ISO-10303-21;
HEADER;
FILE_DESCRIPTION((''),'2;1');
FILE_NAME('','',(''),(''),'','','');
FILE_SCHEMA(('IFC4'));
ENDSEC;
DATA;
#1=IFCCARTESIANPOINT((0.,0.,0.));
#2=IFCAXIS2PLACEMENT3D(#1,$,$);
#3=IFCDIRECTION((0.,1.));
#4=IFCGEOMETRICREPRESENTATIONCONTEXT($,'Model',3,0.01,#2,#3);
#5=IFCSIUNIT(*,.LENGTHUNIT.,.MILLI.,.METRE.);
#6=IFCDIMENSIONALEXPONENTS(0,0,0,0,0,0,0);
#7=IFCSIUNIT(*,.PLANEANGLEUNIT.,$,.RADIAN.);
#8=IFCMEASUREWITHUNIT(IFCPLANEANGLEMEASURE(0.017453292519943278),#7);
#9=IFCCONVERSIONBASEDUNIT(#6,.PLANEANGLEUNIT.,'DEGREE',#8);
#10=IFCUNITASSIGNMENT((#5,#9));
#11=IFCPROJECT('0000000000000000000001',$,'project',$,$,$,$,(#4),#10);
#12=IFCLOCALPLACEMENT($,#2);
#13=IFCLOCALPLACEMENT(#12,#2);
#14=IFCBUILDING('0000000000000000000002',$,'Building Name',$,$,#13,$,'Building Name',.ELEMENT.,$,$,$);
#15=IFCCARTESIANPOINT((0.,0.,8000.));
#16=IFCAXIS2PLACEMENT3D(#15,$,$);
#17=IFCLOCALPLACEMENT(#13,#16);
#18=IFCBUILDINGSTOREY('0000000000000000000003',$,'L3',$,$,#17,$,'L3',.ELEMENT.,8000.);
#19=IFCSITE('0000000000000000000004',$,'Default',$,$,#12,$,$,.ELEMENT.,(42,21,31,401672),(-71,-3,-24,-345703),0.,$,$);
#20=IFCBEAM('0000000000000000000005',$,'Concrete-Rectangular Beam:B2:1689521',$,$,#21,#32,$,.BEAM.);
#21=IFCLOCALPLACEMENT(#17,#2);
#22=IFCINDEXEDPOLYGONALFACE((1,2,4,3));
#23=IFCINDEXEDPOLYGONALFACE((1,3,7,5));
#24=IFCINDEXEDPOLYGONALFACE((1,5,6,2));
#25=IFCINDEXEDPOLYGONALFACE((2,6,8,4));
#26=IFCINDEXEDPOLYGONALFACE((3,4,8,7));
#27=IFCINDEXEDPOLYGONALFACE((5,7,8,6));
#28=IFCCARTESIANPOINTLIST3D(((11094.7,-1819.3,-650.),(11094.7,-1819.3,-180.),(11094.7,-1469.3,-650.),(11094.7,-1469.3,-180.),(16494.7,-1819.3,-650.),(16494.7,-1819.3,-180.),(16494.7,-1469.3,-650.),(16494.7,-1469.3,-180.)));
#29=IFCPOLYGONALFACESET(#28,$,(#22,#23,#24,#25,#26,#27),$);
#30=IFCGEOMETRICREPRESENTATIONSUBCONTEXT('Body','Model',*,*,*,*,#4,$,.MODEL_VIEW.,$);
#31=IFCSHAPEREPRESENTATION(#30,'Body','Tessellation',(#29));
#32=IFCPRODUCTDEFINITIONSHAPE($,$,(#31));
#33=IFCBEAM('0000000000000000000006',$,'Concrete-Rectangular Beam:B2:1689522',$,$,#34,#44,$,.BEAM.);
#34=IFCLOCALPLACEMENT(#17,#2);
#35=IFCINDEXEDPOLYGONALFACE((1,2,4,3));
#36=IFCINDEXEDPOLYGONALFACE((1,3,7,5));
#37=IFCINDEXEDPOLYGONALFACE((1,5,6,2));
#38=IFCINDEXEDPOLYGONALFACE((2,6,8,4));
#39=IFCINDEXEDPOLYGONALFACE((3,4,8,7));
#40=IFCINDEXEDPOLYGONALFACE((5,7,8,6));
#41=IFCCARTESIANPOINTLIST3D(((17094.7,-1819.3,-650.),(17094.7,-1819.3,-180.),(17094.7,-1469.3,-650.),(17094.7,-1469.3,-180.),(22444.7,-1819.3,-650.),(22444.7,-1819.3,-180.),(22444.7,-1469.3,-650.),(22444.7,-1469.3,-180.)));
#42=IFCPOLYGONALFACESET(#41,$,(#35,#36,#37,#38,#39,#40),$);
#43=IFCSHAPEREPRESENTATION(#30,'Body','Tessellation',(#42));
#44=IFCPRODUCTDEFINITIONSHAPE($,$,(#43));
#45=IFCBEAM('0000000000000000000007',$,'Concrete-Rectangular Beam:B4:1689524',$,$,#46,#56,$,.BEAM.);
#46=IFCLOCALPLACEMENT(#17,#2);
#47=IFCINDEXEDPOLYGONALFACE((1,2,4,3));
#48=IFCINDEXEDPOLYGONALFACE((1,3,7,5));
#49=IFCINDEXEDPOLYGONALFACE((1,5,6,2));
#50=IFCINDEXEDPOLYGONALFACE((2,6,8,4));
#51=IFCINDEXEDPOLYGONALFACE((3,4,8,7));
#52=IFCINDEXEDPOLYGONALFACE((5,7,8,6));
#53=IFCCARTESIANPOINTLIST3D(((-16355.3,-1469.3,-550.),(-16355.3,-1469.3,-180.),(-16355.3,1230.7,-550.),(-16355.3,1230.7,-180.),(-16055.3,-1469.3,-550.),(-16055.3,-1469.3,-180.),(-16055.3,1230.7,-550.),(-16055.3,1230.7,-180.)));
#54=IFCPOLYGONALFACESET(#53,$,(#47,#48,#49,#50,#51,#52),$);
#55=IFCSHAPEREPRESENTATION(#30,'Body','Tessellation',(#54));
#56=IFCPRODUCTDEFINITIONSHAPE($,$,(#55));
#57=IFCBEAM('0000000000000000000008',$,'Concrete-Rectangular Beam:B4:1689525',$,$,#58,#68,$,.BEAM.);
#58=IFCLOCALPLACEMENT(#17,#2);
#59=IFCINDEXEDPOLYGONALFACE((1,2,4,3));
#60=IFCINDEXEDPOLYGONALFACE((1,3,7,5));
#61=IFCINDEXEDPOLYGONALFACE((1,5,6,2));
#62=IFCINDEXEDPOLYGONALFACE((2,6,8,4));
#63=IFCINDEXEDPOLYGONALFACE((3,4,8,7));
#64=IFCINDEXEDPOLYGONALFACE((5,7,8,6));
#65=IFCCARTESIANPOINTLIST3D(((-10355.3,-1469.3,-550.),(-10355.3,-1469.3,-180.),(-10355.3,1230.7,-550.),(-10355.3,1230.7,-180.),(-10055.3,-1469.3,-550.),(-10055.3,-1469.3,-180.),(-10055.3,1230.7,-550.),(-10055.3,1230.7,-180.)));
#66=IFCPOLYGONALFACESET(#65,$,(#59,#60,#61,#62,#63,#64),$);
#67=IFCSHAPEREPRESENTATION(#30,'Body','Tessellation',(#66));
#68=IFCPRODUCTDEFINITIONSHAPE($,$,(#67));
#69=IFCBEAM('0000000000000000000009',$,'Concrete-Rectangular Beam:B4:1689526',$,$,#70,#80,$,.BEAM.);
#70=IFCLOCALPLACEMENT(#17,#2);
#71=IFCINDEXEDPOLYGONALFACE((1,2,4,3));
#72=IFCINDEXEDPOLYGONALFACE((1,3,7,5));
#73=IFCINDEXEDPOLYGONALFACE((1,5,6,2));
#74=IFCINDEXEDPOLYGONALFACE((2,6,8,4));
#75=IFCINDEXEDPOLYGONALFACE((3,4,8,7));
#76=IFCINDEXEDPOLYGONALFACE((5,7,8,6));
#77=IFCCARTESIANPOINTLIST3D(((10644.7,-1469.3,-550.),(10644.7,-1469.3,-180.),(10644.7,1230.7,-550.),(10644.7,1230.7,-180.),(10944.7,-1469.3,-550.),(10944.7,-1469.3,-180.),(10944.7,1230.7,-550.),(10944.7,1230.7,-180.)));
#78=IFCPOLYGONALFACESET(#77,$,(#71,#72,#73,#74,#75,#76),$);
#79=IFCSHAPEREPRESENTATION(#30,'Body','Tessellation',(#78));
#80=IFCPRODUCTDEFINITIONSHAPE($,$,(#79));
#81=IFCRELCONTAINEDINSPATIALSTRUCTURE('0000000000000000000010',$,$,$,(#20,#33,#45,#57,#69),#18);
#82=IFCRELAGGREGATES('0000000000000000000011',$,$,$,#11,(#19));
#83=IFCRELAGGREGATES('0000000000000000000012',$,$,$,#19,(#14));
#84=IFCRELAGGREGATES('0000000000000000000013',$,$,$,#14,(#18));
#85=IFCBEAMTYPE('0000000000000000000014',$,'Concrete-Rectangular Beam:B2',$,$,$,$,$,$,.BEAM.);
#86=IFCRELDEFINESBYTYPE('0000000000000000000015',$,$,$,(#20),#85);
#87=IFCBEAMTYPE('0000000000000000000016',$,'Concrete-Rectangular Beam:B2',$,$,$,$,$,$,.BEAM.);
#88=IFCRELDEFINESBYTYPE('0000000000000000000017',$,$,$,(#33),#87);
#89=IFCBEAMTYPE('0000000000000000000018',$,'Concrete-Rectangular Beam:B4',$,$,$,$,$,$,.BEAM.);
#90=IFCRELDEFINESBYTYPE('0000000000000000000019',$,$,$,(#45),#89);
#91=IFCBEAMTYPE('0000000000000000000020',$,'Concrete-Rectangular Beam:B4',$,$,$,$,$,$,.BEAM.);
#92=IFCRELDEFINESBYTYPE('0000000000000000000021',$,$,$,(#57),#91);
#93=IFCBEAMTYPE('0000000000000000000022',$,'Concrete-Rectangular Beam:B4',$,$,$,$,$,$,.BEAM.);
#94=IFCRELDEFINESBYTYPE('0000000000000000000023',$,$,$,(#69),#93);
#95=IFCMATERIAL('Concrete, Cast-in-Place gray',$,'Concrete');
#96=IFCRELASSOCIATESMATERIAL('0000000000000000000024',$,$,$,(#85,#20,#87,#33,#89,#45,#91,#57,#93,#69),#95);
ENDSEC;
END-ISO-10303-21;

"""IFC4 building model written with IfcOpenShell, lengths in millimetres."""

from ifc_helpers import new_model, entity, si_unit, converted_unit, direction, frame, origin, place, context, subcontext, project, spatial, indexed_curve, outline, extrude, source, transform, mapped, material, type_object, type_shapes, element, save


model = new_model("IFC4")

# Units and contexts
model_context = context("Model", 3, precision=0.01, world=origin(), true_north=direction((0.0, 1.0)))
body_context = subcontext(model_context, "Body", "Model", "MODEL_VIEW")
ifc_project = project(units=[si_unit("LENGTHUNIT", "METRE", prefix="MILLI"), converted_unit("PLANEANGLEUNIT", "DEGREE", entity("IfcPlaneAngleMeasure", 0.017453292519943278), si_unit("PLANEANGLEUNIT", "RADIAN"), dimensions=[0, 0, 0, 0, 0, 0, 0])], contexts=[model_context])

# Site, building, storey
site_placement = place(None, origin())
site = spatial("IfcSite", under=ifc_project, at=site_placement, Name="Default", CompositionType="ELEMENT", RefLatitude=(42, 21, 31, 401672), RefLongitude=(-71, -3, -24, -345703), RefElevation=0.0)
building_placement = place(site_placement, origin())
building = spatial("IfcBuilding", under=site, at=building_placement, Name="Building Name", LongName="Building Name", CompositionType="ELEMENT")
storey_placement = place(building_placement, frame((0.0, 0.0, 8000.0)))
storey = spatial("IfcBuildingStorey", under=building, at=storey_placement, Name="L3", LongName="L3", CompositionType="ELEMENT", Elevation=8000.0)

# Beams
ifc_material = material(Name="Concrete, Cast-in-Place gray", Category="Concrete")
beam_type_1 = type_object("IfcBeamType", Name="Concrete-Rectangular Beam:B2", PredefinedType="BEAM", material=ifc_material)
shared_shape_1 = source(origin(), body_context, "Body", "SweptSolid", [
    extrude(outline(indexed_curve([(-235.0, -175.0), (235.0, -175.0), (235.0, 175.0), (-235.0, 175.0), (-235.0, -175.0)], self_intersect=False)), frame((11094.7, -1644.3, 7585.0), z_axis=(1.0, 0.0, 0.0), x_axis=(0.0, 0.0, -1.0)), (0.0, 0.0, 1.0), 5400.0),
])
type_shapes(beam_type_1, [shared_shape_1])
beam_1_placement = place(storey_placement, frame((0.0, 0.0, -8000.0)))
element("IfcBeam", 1, at=beam_1_placement, inside=storey, type_object=beam_type_1, material=ifc_material, Name="Concrete-Rectangular Beam:B2:1689521", PredefinedType="BEAM", context=body_context, shape_type="MappedRepresentation", body=[
    mapped(shared_shape_1, transform((0.0, 0.0, 0.0), scale=1.0)),
])
beam_type_2 = type_object("IfcBeamType", Name="Concrete-Rectangular Beam:B2", PredefinedType="BEAM", material=ifc_material)
shared_shape_2 = source(origin(), body_context, "Body", "SweptSolid", [
    extrude(outline(indexed_curve([(-235.0, -175.0), (235.0, -175.0), (235.0, 175.0), (-235.0, 175.0), (-235.0, -175.0)], self_intersect=False)), frame((17094.7, -1644.3, 7585.0), z_axis=(1.0, 0.0, 0.0), x_axis=(0.0, 0.0, -1.0)), (0.0, 0.0, 1.0), 5350.0),
])
type_shapes(beam_type_2, [shared_shape_2])
beam_2_placement = place(storey_placement, frame((0.0, 0.0, -8000.0)))
element("IfcBeam", 2, at=beam_2_placement, inside=storey, type_object=beam_type_2, material=ifc_material, Name="Concrete-Rectangular Beam:B2:1689522", PredefinedType="BEAM", context=body_context, shape_type="MappedRepresentation", body=[
    mapped(shared_shape_2, transform((0.0, 0.0, 0.0), scale=1.0)),
])
beam_type_3 = type_object("IfcBeamType", Name="Concrete-Rectangular Beam:B4", PredefinedType="BEAM", material=ifc_material)
shared_shape_3 = source(origin(), body_context, "Body", "SweptSolid", [
    extrude(outline(indexed_curve([(-150.0, -185.0), (150.0, -185.0), (150.0, 185.0), (-150.0, 185.0), (-150.0, -185.0)], self_intersect=False)), frame((-16205.3, 1230.7, 7635.0), z_axis=(0.0, -1.0, 0.0), x_axis=(-1.0, 0.0, 0.0)), (0.0, 0.0, 1.0), 2700.0),
])
type_shapes(beam_type_3, [shared_shape_3])
beam_3_placement = place(storey_placement, frame((0.0, 0.0, -8000.0)))
element("IfcBeam", 3, at=beam_3_placement, inside=storey, type_object=beam_type_3, material=ifc_material, Name="Concrete-Rectangular Beam:B4:1689524", PredefinedType="BEAM", context=body_context, shape_type="MappedRepresentation", body=[
    mapped(shared_shape_3, transform((0.0, 0.0, 0.0), scale=1.0)),
])
beam_type_4 = type_object("IfcBeamType", Name="Concrete-Rectangular Beam:B4", PredefinedType="BEAM", material=ifc_material)
shared_shape_4 = source(origin(), body_context, "Body", "SweptSolid", [
    extrude(outline(indexed_curve([(-150.0, -185.0), (150.0, -185.0), (150.0, 185.0), (-150.0, 185.0), (-150.0, -185.0)], self_intersect=False)), frame((-10205.3, 1230.7, 7635.0), z_axis=(0.0, -1.0, 0.0), x_axis=(-1.0, 0.0, 0.0)), (0.0, 0.0, 1.0), 2700.0),
])
type_shapes(beam_type_4, [shared_shape_4])
beam_4_placement = place(storey_placement, frame((0.0, 0.0, -8000.0)))
element("IfcBeam", 4, at=beam_4_placement, inside=storey, type_object=beam_type_4, material=ifc_material, Name="Concrete-Rectangular Beam:B4:1689525", PredefinedType="BEAM", context=body_context, shape_type="MappedRepresentation", body=[
    mapped(shared_shape_4, transform((0.0, 0.0, 0.0), scale=1.0)),
])
beam_type_5 = type_object("IfcBeamType", Name="Concrete-Rectangular Beam:B4", PredefinedType="BEAM", material=ifc_material)
shared_shape_5 = source(origin(), body_context, "Body", "SweptSolid", [
    extrude(outline(indexed_curve([(-150.0, -185.0), (150.0, -185.0), (150.0, 185.0), (-150.0, 185.0), (-150.0, -185.0)], self_intersect=False)), frame((10794.7, 1230.7, 7635.0), z_axis=(0.0, -1.0, 0.0), x_axis=(-1.0, 0.0, 0.0)), (0.0, 0.0, 1.0), 2700.0),
])
type_shapes(beam_type_5, [shared_shape_5])
beam_5_placement = place(storey_placement, frame((0.0, 0.0, -8000.0)))
element("IfcBeam", 5, at=beam_5_placement, inside=storey, type_object=beam_type_5, material=ifc_material, Name="Concrete-Rectangular Beam:B4:1689526", PredefinedType="BEAM", context=body_context, shape_type="MappedRepresentation", body=[
    mapped(shared_shape_5, transform((0.0, 0.0, 0.0), scale=1.0)),
])

save(model, "model.ifc")
